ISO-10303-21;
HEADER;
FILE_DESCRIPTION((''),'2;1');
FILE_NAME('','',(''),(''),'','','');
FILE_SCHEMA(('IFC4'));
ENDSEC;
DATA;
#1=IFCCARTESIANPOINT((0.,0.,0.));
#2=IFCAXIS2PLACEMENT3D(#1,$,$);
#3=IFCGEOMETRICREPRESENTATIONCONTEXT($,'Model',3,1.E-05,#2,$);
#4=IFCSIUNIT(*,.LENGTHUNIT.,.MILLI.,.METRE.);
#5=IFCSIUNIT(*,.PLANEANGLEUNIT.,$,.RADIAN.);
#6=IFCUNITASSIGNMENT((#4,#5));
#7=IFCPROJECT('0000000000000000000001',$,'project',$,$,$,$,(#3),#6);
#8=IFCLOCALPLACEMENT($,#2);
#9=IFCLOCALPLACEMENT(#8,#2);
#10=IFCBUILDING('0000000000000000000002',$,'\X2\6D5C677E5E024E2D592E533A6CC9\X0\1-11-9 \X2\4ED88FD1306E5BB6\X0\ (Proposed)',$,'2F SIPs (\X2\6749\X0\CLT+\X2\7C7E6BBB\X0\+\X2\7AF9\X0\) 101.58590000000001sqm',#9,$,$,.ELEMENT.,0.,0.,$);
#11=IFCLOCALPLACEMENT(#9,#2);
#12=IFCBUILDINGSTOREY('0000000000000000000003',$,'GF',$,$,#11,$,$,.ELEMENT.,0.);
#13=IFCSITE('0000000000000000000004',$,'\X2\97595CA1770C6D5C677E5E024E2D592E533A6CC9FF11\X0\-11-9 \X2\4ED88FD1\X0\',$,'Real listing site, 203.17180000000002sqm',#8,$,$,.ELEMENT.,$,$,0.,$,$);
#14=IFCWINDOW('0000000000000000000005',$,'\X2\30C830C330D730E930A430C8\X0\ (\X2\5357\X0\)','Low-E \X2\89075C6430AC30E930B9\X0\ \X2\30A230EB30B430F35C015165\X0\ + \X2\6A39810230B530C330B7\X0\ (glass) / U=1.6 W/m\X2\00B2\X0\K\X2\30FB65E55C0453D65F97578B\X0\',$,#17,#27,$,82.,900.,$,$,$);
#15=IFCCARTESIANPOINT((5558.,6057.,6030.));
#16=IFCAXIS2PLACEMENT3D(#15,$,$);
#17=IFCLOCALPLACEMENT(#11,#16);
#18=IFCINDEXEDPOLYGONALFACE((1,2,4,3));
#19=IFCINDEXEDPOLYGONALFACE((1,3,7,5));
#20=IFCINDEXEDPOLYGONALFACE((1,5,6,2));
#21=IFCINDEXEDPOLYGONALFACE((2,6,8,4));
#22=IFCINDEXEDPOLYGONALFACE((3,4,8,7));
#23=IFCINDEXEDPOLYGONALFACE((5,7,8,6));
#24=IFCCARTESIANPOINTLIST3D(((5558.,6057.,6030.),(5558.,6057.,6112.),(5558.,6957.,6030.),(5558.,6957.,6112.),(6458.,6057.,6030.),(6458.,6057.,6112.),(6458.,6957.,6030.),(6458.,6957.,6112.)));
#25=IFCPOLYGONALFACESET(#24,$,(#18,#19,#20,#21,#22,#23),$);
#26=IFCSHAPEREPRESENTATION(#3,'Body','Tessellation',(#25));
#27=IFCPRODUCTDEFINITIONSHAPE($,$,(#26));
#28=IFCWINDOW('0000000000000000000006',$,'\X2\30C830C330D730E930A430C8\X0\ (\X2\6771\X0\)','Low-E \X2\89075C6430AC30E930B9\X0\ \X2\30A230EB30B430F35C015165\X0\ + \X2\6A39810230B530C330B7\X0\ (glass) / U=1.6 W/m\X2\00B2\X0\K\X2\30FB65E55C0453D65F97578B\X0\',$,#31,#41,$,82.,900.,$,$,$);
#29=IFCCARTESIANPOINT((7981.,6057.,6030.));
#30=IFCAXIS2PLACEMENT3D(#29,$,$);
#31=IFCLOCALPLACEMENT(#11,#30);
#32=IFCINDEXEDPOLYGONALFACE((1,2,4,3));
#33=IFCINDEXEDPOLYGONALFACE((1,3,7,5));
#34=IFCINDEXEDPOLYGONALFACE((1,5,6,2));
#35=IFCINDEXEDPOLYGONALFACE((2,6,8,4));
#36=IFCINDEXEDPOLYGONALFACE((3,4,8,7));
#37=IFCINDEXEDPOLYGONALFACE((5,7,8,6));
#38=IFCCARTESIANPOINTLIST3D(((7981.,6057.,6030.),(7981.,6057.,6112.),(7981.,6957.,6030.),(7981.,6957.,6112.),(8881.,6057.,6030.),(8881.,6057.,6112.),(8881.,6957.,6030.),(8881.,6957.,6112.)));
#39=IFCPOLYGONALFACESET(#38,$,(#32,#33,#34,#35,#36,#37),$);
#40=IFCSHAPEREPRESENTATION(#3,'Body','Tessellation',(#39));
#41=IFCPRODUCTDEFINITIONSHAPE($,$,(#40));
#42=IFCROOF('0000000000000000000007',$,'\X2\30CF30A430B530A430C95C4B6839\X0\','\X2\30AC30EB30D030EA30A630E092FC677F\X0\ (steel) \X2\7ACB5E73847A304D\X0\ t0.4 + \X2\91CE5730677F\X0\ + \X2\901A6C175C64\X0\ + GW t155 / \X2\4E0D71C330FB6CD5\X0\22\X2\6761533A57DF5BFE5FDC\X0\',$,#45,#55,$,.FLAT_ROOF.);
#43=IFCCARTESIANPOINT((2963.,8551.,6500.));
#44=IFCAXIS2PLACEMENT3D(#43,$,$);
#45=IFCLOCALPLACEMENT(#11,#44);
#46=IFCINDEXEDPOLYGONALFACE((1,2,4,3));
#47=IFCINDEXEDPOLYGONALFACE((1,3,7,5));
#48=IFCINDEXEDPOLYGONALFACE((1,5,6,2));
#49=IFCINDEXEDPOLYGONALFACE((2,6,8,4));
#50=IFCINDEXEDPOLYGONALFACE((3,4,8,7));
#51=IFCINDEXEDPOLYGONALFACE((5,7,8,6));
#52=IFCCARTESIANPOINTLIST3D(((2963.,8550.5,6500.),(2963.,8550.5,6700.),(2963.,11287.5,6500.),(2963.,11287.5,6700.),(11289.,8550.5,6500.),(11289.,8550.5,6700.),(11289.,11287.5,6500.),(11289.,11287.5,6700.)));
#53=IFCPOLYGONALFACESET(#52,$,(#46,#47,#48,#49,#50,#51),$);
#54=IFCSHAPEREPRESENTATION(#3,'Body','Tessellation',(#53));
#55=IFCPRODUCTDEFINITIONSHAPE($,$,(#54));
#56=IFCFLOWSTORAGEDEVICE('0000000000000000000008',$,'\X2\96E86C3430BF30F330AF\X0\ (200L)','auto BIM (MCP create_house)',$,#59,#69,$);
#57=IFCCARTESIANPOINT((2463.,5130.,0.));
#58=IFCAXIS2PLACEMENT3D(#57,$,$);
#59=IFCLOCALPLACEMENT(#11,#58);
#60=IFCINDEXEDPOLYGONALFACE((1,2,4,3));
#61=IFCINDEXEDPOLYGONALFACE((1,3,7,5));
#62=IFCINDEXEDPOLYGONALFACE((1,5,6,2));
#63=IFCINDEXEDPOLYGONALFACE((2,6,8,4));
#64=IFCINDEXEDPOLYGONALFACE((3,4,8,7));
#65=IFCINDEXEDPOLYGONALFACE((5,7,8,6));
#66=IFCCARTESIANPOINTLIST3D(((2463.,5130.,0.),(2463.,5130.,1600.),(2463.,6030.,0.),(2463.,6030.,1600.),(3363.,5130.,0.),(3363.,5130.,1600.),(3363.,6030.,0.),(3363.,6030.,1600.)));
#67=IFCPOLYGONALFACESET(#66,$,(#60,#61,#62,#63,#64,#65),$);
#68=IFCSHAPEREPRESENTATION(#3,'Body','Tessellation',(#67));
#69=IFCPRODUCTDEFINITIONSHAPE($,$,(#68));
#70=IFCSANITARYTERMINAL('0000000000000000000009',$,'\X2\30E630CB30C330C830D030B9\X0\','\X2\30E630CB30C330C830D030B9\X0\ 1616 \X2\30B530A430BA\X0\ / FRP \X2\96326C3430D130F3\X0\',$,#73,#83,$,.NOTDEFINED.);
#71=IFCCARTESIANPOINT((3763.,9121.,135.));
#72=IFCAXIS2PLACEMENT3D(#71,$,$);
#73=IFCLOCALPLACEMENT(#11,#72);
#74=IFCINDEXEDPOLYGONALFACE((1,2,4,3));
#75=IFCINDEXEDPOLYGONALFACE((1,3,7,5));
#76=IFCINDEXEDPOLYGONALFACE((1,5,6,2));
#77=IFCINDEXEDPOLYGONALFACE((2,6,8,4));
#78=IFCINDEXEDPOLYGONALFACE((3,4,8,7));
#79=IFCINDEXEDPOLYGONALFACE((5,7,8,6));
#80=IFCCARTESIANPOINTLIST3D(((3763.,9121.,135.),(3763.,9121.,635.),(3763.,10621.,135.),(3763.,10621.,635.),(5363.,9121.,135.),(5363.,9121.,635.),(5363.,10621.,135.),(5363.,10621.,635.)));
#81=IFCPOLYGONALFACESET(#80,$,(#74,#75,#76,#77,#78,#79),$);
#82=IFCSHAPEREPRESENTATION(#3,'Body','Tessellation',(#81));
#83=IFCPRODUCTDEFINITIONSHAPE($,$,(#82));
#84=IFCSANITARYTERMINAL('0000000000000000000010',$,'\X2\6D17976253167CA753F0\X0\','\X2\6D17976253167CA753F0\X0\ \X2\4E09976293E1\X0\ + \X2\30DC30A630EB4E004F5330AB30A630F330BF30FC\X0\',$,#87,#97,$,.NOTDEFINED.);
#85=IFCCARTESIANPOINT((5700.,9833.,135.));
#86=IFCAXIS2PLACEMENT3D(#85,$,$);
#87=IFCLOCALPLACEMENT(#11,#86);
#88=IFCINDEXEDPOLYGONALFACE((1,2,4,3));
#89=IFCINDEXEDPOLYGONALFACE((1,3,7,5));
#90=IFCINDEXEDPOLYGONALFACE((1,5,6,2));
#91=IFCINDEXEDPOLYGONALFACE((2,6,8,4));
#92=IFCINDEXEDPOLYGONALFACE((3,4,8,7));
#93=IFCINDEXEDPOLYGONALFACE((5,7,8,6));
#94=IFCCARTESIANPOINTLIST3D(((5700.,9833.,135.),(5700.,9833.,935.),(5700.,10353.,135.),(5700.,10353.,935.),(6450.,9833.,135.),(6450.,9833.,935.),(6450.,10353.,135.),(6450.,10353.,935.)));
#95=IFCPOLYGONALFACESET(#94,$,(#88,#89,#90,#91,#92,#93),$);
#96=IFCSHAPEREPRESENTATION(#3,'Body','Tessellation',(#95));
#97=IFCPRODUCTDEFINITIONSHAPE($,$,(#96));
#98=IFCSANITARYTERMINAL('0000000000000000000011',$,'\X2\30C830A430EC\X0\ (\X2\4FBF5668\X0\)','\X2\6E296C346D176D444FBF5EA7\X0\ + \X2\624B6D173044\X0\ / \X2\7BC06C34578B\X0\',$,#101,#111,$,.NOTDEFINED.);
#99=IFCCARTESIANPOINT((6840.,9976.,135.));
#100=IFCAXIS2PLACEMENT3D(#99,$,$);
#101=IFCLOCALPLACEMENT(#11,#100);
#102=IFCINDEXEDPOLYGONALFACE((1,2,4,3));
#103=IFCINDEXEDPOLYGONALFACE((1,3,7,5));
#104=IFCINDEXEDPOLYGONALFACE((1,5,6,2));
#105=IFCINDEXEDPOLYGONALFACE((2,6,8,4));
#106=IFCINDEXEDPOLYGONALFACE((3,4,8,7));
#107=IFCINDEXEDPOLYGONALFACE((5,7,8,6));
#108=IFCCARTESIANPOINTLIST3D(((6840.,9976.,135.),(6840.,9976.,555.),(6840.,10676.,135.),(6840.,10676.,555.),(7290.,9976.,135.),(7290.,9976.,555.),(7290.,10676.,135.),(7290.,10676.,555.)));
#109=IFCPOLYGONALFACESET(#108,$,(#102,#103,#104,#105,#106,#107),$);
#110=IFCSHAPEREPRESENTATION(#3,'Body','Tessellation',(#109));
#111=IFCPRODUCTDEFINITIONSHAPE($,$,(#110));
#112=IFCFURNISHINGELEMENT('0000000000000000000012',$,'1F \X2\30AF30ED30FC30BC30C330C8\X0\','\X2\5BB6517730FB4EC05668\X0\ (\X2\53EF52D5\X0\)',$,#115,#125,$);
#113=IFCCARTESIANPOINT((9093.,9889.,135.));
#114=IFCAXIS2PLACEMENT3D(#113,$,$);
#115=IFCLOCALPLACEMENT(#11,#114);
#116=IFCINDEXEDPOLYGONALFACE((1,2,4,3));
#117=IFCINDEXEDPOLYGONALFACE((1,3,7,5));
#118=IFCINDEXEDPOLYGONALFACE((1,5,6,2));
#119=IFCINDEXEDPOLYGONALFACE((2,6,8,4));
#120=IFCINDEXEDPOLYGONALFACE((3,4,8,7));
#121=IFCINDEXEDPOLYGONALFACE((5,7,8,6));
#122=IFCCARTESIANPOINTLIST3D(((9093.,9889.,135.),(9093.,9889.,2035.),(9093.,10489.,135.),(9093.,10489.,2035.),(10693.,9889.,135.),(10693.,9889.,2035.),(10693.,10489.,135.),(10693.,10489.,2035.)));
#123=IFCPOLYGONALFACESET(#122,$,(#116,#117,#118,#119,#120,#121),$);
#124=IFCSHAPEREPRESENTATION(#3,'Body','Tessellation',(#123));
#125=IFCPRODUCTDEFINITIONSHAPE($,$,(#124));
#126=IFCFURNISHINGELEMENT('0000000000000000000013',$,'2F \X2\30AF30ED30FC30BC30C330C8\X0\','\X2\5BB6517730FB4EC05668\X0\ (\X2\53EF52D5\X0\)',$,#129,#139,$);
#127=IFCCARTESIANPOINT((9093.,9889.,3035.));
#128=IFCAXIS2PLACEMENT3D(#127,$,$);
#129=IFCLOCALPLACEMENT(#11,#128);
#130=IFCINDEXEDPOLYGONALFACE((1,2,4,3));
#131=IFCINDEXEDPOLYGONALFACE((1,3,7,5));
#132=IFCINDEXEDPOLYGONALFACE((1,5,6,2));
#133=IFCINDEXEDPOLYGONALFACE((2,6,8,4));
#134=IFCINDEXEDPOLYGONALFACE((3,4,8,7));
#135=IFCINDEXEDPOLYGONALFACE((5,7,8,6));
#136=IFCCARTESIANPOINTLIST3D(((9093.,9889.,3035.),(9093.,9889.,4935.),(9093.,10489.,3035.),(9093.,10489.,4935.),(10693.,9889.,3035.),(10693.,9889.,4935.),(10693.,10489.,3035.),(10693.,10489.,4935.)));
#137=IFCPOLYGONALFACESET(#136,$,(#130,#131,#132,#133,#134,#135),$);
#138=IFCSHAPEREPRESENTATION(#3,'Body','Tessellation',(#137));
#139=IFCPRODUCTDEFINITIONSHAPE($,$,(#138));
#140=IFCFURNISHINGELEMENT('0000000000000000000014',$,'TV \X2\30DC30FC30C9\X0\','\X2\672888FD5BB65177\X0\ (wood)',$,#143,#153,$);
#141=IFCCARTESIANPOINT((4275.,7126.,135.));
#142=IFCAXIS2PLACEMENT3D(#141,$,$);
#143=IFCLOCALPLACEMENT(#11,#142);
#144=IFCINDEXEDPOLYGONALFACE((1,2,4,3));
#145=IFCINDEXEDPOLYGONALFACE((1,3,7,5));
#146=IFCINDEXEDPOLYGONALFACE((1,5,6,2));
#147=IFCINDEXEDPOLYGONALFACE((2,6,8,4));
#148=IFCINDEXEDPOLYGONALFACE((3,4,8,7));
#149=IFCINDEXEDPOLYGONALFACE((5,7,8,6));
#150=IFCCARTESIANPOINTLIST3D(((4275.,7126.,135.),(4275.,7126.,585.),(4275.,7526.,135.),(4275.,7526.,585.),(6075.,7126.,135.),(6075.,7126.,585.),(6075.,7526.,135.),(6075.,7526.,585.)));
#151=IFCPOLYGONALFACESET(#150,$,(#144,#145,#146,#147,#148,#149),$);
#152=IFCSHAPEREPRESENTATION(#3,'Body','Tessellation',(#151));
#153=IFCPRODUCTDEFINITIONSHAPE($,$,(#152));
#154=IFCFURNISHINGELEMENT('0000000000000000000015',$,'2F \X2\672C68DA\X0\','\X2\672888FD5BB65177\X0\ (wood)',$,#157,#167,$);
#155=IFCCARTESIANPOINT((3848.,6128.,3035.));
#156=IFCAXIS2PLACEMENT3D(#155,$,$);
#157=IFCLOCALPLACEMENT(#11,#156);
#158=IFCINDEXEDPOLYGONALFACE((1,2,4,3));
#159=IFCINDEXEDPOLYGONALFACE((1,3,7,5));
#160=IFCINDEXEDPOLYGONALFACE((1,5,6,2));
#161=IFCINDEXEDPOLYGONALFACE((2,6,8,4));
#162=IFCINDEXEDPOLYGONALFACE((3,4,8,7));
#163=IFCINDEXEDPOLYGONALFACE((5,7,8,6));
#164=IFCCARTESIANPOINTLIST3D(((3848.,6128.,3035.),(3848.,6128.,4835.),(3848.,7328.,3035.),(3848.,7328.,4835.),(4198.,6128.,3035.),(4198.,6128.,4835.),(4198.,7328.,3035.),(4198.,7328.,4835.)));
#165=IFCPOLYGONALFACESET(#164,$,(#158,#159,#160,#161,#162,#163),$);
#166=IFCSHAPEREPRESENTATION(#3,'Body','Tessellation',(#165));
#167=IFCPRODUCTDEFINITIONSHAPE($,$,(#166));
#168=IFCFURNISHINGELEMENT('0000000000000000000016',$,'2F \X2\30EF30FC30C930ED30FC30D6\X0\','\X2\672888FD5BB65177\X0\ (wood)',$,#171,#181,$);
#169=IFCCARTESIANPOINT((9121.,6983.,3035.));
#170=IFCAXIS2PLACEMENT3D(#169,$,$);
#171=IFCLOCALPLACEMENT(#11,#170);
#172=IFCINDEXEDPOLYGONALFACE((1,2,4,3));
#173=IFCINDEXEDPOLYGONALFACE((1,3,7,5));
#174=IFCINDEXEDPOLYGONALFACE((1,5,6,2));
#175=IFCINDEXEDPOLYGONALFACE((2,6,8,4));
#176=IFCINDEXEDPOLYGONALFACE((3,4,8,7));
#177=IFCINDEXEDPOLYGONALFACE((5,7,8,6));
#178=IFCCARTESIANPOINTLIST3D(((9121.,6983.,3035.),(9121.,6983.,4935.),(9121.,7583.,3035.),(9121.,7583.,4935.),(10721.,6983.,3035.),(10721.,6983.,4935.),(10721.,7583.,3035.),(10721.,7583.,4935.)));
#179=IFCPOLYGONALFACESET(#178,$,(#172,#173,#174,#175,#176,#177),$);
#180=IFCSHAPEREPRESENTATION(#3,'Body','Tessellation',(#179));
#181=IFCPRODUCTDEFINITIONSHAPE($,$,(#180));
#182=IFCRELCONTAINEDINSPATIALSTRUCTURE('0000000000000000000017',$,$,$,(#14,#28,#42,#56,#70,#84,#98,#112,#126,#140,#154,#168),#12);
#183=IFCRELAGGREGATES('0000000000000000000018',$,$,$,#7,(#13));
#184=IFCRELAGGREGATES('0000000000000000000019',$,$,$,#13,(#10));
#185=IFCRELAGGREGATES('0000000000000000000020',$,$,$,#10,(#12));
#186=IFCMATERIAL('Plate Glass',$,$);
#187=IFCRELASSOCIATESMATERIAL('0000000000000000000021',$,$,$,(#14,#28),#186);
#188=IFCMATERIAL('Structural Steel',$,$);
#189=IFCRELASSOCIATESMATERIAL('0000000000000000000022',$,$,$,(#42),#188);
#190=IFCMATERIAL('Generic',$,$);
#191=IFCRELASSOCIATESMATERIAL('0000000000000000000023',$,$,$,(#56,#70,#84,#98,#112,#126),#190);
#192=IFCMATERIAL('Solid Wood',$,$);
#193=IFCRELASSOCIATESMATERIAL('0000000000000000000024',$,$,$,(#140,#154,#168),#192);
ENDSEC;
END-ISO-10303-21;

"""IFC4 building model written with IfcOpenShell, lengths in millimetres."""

from ifc_helpers import new_model, si_unit, frame, frame_2d, origin, place, context, project, spatial, rectangle, extrude, material, element, save


model = new_model("IFC4")

# Units and contexts
model_context = context("Model", 3, precision=1e-05, world=origin())
ifc_project = project(units=[si_unit("LENGTHUNIT", "METRE", prefix="MILLI"), si_unit("PLANEANGLEUNIT", "RADIAN")], contexts=[model_context])

# Site, building, storey
site_placement = place(None, origin())
site = spatial("IfcSite", under=ifc_project, at=site_placement, Name="静岡県浜松市中央区泉１-11-9 付近", ObjectType="Real listing site, 203.17180000000002sqm", CompositionType="ELEMENT", RefElevation=0.0)
building_placement = place(site_placement, origin())
building = spatial("IfcBuilding", under=site, at=building_placement, Name="浜松市中央区泉1-11-9 付近の家 (Proposed)", ObjectType="2F SIPs (杉CLT+籾殻+竹) 101.58590000000001sqm", CompositionType="ELEMENT", ElevationOfRefHeight=0.0, ElevationOfTerrain=0.0)
storey_placement = place(building_placement, origin())
storey = spatial("IfcBuildingStorey", under=building, at=storey_placement, Name="GF", CompositionType="ELEMENT", Elevation=0.0)

# Shared definitions
ifc_material_1 = material(Name="Solid Wood")
ifc_material_2 = material(Name="Plate Glass")

# Windows
window_1_placement = place(storey_placement, frame((5558.0, 6057.0, 6030.0)))
element("IfcWindow", 1, at=window_1_placement, inside=storey, material=ifc_material_2, Name="トップライト (南)", Description="Low-E 複層ガラス アルゴン封入 + 樹脂サッシ (glass) / U=1.6 W/m²K・日射取得型", OverallHeight=82.0, OverallWidth=900.0, context=model_context, shape_type="SweptSolid", body=[
    extrude(rectangle(XDim=900.0, YDim=900.0, at=frame_2d((450.0, 450.0))), frame((5558.0, 6057.0, 6030.0)), (0.0, 0.0, 1.0), 82.0),
])
window_2_placement = place(storey_placement, frame((7981.0, 6057.0, 6030.0)))
element("IfcWindow", 2, at=window_2_placement, inside=storey, material=ifc_material_2, Name="トップライト (東)", Description="Low-E 複層ガラス アルゴン封入 + 樹脂サッシ (glass) / U=1.6 W/m²K・日射取得型", OverallHeight=82.0, OverallWidth=900.0, context=model_context, shape_type="SweptSolid", body=[
    extrude(rectangle(XDim=900.0, YDim=900.0, at=frame_2d((450.0, 450.0))), frame((7981.0, 6057.0, 6030.0)), (0.0, 0.0, 1.0), 82.0),
])

# Roof
ifc_material_3 = material(Name="Structural Steel")
roof_placement = place(storey_placement, frame((2963.0, 8551.0, 6500.0)))
element("IfcRoof", 3, at=roof_placement, inside=storey, material=ifc_material_3, Name="ハイサイド屋根", Description="ガルバリウム鋼板 (steel) 立平葺き t0.4 + 野地板 + 通気層 + GW t155 / 不燃・法22条区域対応", PredefinedType="FLAT_ROOF", context=model_context, shape_type="SweptSolid", body=[
    extrude(rectangle(XDim=8326.0, YDim=2737.0, at=frame_2d((4163.0, 1368.0))), frame((2963.0, 8551.0, 6500.0)), (0.0, 0.0, 1.0), 200.0),
])

# Flow storage device
ifc_material_4 = material(Name="Generic")
flow_storage_device_placement = place(storey_placement, frame((2463.0, 5130.0, 0.0)))
element("IfcFlowStorageDevice", 4, at=flow_storage_device_placement, inside=storey, material=ifc_material_4, Name="雨水タンク (200L)", Description="auto BIM (MCP create_house)", context=model_context, shape_type="SweptSolid", body=[
    extrude(rectangle(XDim=900.0, YDim=900.0, at=frame_2d((450.0, 450.0))), frame((2463.0, 5130.0, 0.0)), (0.0, 0.0, 1.0), 1600.0),
])

# Sanitary terminals
sanitary_terminal_1_placement = place(storey_placement, frame((3763.0, 9121.0, 135.0)))
element("IfcSanitaryTerminal", 5, at=sanitary_terminal_1_placement, inside=storey, material=ifc_material_4, Name="ユニットバス", Description="ユニットバス 1616 サイズ / FRP 防水パン", PredefinedType="NOTDEFINED", context=model_context, shape_type="SweptSolid", body=[
    extrude(rectangle(XDim=1600.0, YDim=1500.0, at=frame_2d((800.0, 750.0))), frame((3763.0, 9121.0, 135.0)), (0.0, 0.0, 1.0), 500.0),
])
sanitary_terminal_2_placement = place(storey_placement, frame((5700.0, 9833.0, 135.0)))
element("IfcSanitaryTerminal", 6, at=sanitary_terminal_2_placement, inside=storey, material=ifc_material_4, Name="洗面化粧台", Description="洗面化粧台 三面鏡 + ボウル一体カウンター", PredefinedType="NOTDEFINED", context=model_context, shape_type="SweptSolid", body=[
    extrude(rectangle(XDim=750.0, YDim=520.0, at=frame_2d((375.0, 260.0))), frame((5700.0, 9833.0, 135.0)), (0.0, 0.0, 1.0), 800.0),
])
sanitary_terminal_3_placement = place(storey_placement, frame((6840.0, 9976.0, 135.0)))
element("IfcSanitaryTerminal", 7, at=sanitary_terminal_3_placement, inside=storey, material=ifc_material_4, Name="トイレ (便器)", Description="温水洗浄便座 + 手洗い / 節水型", PredefinedType="NOTDEFINED", context=model_context, shape_type="SweptSolid", body=[
    extrude(rectangle(XDim=450.0, YDim=700.0, at=frame_2d((225.0, 350.0))), frame((6840.0, 9976.0, 135.0)), (0.0, 0.0, 1.0), 420.0),
])

# Furnishing elements
furnishing_1_placement = place(storey_placement, frame((9093.0, 9889.0, 135.0)))
element("IfcFurnishingElement", 8, at=furnishing_1_placement, inside=storey, material=ifc_material_4, Name="1F クローゼット", Description="家具・什器 (可動)", context=model_context, shape_type="SweptSolid", body=[
    extrude(rectangle(XDim=1600.0, YDim=600.0, at=frame_2d((800.0, 300.0))), frame((9093.0, 9889.0, 135.0)), (0.0, 0.0, 1.0), 1900.0),
])
furnishing_2_placement = place(storey_placement, frame((9093.0, 9889.0, 3035.0)))
element("IfcFurnishingElement", 9, at=furnishing_2_placement, inside=storey, material=ifc_material_4, Name="2F クローゼット", Description="家具・什器 (可動)", context=model_context, shape_type="SweptSolid", body=[
    extrude(rectangle(XDim=1600.0, YDim=600.0, at=frame_2d((800.0, 300.0))), frame((9093.0, 9889.0, 3035.0)), (0.0, 0.0, 1.0), 1900.0),
])
furnishing_3_placement = place(storey_placement, frame((4275.0, 7126.0, 135.0)))
element("IfcFurnishingElement", 10, at=furnishing_3_placement, inside=storey, material=ifc_material_1, Name="TV ボード", Description="木製家具 (wood)", context=model_context, shape_type="SweptSolid", body=[
    extrude(rectangle(XDim=1800.0, YDim=400.0, at=frame_2d((900.0, 200.0))), frame((4275.0, 7126.0, 135.0)), (0.0, 0.0, 1.0), 450.0),
])
furnishing_4_placement = place(storey_placement, frame((3848.0, 6128.0, 3035.0)))
element("IfcFurnishingElement", 11, at=furnishing_4_placement, inside=storey, material=ifc_material_1, Name="2F 本棚", Description="木製家具 (wood)", context=model_context, shape_type="SweptSolid", body=[
    extrude(rectangle(XDim=350.0, YDim=1200.0, at=frame_2d((175.0, 600.0))), frame((3848.0, 6128.0, 3035.0)), (0.0, 0.0, 1.0), 1800.0),
])
furnishing_5_placement = place(storey_placement, frame((9121.0, 6983.0, 3035.0)))
element("IfcFurnishingElement", 12, at=furnishing_5_placement, inside=storey, material=ifc_material_1, Name="2F ワードローブ", Description="木製家具 (wood)", context=model_context, shape_type="SweptSolid", body=[
    extrude(rectangle(XDim=1600.0, YDim=600.0, at=frame_2d((800.0, 300.0))), frame((9121.0, 6983.0, 3035.0)), (0.0, 0.0, 1.0), 1900.0),
])

save(model, "model.ifc")
